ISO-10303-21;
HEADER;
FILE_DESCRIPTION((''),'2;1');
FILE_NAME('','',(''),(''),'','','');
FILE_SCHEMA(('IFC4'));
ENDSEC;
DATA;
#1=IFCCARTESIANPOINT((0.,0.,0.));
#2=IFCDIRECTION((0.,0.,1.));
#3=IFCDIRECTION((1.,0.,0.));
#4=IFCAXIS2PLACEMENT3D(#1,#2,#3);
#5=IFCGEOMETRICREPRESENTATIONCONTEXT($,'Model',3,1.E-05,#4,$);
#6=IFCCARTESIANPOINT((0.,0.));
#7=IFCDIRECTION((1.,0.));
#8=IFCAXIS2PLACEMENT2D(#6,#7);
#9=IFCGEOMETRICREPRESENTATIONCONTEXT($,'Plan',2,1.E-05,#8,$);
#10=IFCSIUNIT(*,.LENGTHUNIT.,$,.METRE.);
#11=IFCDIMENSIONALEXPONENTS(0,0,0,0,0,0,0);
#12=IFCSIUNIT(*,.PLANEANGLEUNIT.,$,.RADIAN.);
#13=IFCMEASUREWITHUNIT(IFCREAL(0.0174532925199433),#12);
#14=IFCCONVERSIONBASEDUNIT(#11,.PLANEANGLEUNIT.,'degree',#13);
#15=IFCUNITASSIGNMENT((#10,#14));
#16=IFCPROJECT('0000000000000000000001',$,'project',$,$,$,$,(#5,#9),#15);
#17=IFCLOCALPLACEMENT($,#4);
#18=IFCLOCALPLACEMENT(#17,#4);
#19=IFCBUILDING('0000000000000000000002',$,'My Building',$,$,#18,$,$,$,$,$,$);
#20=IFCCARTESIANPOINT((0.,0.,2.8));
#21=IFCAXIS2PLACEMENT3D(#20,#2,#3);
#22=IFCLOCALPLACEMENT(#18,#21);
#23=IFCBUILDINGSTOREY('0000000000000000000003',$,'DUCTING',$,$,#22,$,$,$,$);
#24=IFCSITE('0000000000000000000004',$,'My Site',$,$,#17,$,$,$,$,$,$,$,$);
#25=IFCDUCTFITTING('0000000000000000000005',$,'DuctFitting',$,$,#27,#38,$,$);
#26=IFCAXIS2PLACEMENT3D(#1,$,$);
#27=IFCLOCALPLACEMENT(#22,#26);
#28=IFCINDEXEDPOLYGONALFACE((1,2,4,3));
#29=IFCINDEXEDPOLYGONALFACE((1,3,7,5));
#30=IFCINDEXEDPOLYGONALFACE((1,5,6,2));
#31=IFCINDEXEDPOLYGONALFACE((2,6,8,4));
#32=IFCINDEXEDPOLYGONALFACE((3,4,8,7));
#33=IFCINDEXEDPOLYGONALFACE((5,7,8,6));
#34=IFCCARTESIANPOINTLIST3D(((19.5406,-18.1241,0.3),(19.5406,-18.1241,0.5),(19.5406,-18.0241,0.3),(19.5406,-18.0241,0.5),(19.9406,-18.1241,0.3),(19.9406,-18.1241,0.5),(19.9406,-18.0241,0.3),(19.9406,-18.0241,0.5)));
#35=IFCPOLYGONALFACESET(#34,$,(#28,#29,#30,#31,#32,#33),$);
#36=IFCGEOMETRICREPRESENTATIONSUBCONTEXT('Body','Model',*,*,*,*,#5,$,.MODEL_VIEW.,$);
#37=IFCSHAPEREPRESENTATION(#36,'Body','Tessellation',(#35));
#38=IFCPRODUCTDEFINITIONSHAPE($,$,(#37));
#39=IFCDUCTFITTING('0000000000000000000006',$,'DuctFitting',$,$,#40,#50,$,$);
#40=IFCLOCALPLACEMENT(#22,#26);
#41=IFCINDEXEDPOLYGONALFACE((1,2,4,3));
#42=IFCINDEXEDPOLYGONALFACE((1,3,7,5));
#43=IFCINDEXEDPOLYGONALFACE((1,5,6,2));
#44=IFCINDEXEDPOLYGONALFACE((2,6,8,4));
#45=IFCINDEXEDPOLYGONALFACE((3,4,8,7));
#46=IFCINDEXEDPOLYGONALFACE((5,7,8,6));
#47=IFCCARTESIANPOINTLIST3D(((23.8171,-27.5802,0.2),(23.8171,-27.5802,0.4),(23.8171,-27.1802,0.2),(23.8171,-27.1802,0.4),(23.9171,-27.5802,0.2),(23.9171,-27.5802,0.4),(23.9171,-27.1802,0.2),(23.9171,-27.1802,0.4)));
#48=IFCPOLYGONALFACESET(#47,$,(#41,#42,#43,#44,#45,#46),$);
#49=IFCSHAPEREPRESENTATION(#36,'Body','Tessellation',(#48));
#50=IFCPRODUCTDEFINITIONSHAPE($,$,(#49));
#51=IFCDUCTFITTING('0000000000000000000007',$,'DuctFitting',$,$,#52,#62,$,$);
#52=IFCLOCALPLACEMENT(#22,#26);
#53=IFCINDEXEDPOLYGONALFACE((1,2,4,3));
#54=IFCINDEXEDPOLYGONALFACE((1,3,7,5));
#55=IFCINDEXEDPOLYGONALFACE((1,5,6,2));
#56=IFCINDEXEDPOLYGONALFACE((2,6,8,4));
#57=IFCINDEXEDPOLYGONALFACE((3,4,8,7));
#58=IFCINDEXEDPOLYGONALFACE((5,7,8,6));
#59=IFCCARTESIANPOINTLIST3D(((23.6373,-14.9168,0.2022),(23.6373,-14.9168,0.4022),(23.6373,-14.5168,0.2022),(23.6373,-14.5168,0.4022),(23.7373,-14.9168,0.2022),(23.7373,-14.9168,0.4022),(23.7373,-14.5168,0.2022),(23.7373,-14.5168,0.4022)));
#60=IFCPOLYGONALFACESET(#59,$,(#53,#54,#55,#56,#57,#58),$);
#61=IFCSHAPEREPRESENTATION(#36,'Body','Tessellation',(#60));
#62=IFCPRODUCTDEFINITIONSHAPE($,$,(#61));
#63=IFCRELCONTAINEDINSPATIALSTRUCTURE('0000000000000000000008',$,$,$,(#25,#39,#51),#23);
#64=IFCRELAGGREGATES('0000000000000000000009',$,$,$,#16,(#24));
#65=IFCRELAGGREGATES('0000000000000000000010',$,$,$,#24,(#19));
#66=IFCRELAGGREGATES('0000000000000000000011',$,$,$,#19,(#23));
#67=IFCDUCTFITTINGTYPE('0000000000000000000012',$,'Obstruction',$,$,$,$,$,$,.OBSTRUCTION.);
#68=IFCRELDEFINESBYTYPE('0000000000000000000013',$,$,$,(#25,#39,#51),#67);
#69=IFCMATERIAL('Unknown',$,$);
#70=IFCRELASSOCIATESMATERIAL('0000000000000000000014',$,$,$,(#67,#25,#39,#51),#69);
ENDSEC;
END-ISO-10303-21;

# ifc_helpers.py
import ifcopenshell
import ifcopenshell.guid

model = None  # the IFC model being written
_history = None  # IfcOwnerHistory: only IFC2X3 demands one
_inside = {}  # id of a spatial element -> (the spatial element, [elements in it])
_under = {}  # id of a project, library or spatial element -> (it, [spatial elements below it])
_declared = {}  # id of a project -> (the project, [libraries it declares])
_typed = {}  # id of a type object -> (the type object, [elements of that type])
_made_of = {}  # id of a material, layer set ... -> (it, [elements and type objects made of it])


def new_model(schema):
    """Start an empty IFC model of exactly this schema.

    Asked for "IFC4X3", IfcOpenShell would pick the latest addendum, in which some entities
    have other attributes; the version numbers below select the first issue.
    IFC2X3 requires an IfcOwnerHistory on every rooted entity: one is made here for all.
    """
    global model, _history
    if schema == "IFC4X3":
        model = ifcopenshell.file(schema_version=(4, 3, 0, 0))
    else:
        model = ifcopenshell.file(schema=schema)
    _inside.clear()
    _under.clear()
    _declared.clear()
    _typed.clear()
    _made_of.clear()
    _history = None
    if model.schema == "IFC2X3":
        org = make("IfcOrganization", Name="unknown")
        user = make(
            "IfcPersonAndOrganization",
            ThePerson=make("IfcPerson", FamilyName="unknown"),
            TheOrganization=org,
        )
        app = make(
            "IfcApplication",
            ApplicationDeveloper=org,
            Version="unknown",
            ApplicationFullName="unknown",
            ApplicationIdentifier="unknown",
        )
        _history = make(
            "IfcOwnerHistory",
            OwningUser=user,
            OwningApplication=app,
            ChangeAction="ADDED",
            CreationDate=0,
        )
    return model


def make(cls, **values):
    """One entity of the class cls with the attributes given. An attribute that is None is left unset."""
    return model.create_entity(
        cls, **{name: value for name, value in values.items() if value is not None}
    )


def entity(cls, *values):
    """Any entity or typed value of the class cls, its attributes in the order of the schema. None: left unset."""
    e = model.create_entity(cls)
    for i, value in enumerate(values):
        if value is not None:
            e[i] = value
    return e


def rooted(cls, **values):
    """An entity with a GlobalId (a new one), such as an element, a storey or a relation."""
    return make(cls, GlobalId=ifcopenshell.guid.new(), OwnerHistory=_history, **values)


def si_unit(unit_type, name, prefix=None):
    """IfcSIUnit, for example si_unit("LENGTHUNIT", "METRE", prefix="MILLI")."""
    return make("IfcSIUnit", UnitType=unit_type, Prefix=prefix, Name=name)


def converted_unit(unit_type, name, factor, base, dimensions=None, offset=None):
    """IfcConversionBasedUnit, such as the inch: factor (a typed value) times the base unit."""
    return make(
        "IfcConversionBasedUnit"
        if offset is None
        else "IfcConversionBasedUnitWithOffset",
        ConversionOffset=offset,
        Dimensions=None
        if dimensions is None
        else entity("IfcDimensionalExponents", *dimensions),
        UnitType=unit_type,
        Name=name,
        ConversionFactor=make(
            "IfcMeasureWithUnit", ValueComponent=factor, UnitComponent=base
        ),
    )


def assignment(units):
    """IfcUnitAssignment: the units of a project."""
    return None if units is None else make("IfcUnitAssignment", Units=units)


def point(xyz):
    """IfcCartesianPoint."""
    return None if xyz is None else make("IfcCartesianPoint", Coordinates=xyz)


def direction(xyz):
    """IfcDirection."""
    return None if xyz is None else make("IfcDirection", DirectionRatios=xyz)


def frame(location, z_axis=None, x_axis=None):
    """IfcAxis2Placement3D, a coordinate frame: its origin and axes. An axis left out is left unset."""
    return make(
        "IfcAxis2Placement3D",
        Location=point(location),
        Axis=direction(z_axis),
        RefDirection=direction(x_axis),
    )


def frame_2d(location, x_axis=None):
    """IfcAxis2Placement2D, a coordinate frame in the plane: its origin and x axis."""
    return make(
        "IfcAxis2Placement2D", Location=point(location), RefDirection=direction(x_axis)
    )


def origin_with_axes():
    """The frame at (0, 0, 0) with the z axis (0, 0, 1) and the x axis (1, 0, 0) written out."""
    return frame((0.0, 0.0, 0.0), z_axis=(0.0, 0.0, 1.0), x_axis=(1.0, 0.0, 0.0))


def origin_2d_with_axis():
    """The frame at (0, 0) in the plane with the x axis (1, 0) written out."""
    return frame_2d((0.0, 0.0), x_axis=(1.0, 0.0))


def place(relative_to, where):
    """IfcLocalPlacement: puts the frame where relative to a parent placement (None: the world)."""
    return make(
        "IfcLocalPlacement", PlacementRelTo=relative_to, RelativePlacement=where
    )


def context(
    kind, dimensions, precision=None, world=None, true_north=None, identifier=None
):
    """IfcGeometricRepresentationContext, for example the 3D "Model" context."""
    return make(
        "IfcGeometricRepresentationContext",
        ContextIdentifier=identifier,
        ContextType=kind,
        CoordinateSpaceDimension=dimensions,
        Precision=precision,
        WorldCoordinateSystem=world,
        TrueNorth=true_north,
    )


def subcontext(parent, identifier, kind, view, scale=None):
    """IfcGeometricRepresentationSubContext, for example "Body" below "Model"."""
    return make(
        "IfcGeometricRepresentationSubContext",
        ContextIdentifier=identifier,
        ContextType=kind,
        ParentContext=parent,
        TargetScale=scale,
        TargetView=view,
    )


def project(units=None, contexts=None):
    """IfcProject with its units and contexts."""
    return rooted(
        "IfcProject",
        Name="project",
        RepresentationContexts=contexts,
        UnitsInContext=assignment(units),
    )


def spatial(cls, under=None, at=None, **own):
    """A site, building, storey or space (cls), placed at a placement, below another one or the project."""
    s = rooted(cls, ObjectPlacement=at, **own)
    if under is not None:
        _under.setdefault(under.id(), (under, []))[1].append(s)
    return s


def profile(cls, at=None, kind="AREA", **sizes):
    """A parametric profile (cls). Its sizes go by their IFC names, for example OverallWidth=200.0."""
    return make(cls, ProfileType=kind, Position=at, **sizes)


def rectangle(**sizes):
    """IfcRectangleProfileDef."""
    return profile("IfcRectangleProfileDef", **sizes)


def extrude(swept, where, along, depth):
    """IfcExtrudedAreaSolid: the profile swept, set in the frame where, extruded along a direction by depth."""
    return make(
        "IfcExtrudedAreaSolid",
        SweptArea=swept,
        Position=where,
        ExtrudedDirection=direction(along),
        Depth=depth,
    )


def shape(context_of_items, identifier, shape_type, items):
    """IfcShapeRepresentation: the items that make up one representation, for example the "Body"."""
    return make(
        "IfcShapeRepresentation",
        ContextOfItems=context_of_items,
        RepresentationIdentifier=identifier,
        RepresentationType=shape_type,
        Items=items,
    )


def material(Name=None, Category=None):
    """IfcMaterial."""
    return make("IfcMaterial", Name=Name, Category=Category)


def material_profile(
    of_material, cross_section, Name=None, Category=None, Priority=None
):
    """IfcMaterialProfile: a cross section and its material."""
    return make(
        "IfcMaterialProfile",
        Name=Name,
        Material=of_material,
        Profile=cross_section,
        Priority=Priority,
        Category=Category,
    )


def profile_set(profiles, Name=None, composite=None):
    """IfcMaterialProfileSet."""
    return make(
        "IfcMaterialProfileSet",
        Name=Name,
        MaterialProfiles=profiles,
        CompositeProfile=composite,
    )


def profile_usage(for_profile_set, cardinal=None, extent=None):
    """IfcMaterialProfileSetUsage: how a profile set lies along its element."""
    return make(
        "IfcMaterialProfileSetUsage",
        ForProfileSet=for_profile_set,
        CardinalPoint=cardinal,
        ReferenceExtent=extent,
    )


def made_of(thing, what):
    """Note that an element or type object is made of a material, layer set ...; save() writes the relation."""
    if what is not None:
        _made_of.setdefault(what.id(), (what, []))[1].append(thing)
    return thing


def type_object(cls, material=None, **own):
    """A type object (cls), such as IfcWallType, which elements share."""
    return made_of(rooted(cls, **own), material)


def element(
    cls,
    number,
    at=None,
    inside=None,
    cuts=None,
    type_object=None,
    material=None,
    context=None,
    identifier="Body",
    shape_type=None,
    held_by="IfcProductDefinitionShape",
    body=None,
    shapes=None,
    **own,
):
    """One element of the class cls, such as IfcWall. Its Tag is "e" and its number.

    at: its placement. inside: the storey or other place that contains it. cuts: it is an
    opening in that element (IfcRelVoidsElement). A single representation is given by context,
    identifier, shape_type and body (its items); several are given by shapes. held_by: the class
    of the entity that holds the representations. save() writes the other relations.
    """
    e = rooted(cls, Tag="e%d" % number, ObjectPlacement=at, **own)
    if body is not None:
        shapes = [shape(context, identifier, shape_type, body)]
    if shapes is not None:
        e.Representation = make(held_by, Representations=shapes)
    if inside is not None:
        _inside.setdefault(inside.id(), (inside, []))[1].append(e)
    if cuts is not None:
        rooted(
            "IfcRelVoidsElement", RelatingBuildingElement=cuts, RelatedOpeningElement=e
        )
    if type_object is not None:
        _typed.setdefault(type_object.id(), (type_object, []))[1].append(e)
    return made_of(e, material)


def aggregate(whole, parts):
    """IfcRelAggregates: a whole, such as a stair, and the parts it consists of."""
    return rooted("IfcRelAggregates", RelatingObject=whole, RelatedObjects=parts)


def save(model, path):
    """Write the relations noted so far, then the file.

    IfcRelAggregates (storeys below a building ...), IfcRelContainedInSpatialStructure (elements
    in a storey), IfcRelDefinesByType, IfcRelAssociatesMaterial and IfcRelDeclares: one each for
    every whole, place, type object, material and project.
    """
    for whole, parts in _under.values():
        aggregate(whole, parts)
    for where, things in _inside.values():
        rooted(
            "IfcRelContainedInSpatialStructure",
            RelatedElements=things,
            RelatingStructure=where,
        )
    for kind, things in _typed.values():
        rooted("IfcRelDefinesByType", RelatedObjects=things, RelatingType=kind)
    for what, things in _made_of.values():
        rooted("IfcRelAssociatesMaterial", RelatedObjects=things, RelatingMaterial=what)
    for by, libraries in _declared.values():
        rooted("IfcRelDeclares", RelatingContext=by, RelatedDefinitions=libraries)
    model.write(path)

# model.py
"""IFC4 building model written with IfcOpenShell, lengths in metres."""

from ifc_helpers import new_model, entity, si_unit, converted_unit, frame, origin_with_axes, origin_2d_with_axis, place, context, subcontext, project, spatial, rectangle, extrude, material, material_profile, profile_set, profile_usage, type_object, element, save


model = new_model("IFC4")

# Units and contexts
model_context = context("Model", 3, precision=1e-05, world=origin_with_axes())
plan_context = context("Plan", 2, precision=1e-05, world=origin_2d_with_axis())
body_context = subcontext(model_context, "Body", "Model", "MODEL_VIEW")
ifc_project = project(units=[si_unit("LENGTHUNIT", "METRE"), converted_unit("PLANEANGLEUNIT", "degree", entity("IfcReal", 0.0174532925199433), si_unit("PLANEANGLEUNIT", "RADIAN"), dimensions=[0, 0, 0, 0, 0, 0, 0])], contexts=[model_context, plan_context])

# Site, building, storey
site_placement = place(None, origin_with_axes())
site = spatial("IfcSite", under=ifc_project, at=site_placement, Name="My Site")
building_placement = place(site_placement, origin_with_axes())
building = spatial("IfcBuilding", under=site, at=building_placement, Name="My Building")
storey_placement = place(building_placement, frame((0.0, 0.0, 2.8), z_axis=(0.0, 0.0, 1.0), x_axis=(1.0, 0.0, 0.0)))
storey = spatial("IfcBuildingStorey", under=building, at=storey_placement, Name="DUCTING")

# Shared definitions
ifc_material = material(Name="Unknown")

# Duct fittings
ifc_material_profile_1 = material_profile(ifc_material, rectangle(XDim=0.4, YDim=0.2))
ifc_profile_set_1 = profile_set([ifc_material_profile_1])
duct_fitting_type_1 = type_object("IfcDuctFittingType", Name="Obstruction", PredefinedType="OBSTRUCTION", material=ifc_profile_set_1)
ifc_profile_usage_1 = profile_usage(ifc_profile_set_1, cardinal=5)
duct_fitting_1_placement = place(storey_placement, frame((19.7406, -18.0241, 0.4), z_axis=(0.0, -1.0, 0.000005), x_axis=(1.0, 0.0, 0.0)))
element("IfcDuctFitting", 1, at=duct_fitting_1_placement, inside=storey, type_object=duct_fitting_type_1, material=ifc_profile_usage_1, Name="DuctFitting", context=body_context, shape_type="SweptSolid", body=[
    extrude(rectangle(XDim=0.4, YDim=0.2), origin_with_axes(), (0.0, 0.0, 1.0), 0.1),
])
ifc_profile_usage_2 = profile_usage(ifc_profile_set_1, cardinal=5)
duct_fitting_2_placement = place(storey_placement, frame((23.8171, -27.3802, 0.3), z_axis=(1.0, 0.0, 0.0), x_axis=(0.0, 1.0, 0.0)))
element("IfcDuctFitting", 2, at=duct_fitting_2_placement, inside=storey, type_object=duct_fitting_type_1, material=ifc_profile_usage_2, Name="DuctFitting", context=body_context, shape_type="SweptSolid", body=[
    extrude(rectangle(XDim=0.4, YDim=0.2), origin_with_axes(), (0.0, 0.0, 1.0), 0.1),
])
ifc_profile_usage_3 = profile_usage(ifc_profile_set_1, cardinal=5)
duct_fitting_3_placement = place(storey_placement, frame((23.6373, -14.7168, 0.3022), z_axis=(1.0, 0.0, 0.0), x_axis=(0.0, 1.0, 0.0)))
element("IfcDuctFitting", 3, at=duct_fitting_3_placement, inside=storey, type_object=duct_fitting_type_1, material=ifc_profile_usage_3, Name="DuctFitting", context=body_context, shape_type="SweptSolid", body=[
    extrude(rectangle(XDim=0.4, YDim=0.2), origin_with_axes(), (0.0, 0.0, 1.0), 0.1),
])

save(model, "model.ifc")
